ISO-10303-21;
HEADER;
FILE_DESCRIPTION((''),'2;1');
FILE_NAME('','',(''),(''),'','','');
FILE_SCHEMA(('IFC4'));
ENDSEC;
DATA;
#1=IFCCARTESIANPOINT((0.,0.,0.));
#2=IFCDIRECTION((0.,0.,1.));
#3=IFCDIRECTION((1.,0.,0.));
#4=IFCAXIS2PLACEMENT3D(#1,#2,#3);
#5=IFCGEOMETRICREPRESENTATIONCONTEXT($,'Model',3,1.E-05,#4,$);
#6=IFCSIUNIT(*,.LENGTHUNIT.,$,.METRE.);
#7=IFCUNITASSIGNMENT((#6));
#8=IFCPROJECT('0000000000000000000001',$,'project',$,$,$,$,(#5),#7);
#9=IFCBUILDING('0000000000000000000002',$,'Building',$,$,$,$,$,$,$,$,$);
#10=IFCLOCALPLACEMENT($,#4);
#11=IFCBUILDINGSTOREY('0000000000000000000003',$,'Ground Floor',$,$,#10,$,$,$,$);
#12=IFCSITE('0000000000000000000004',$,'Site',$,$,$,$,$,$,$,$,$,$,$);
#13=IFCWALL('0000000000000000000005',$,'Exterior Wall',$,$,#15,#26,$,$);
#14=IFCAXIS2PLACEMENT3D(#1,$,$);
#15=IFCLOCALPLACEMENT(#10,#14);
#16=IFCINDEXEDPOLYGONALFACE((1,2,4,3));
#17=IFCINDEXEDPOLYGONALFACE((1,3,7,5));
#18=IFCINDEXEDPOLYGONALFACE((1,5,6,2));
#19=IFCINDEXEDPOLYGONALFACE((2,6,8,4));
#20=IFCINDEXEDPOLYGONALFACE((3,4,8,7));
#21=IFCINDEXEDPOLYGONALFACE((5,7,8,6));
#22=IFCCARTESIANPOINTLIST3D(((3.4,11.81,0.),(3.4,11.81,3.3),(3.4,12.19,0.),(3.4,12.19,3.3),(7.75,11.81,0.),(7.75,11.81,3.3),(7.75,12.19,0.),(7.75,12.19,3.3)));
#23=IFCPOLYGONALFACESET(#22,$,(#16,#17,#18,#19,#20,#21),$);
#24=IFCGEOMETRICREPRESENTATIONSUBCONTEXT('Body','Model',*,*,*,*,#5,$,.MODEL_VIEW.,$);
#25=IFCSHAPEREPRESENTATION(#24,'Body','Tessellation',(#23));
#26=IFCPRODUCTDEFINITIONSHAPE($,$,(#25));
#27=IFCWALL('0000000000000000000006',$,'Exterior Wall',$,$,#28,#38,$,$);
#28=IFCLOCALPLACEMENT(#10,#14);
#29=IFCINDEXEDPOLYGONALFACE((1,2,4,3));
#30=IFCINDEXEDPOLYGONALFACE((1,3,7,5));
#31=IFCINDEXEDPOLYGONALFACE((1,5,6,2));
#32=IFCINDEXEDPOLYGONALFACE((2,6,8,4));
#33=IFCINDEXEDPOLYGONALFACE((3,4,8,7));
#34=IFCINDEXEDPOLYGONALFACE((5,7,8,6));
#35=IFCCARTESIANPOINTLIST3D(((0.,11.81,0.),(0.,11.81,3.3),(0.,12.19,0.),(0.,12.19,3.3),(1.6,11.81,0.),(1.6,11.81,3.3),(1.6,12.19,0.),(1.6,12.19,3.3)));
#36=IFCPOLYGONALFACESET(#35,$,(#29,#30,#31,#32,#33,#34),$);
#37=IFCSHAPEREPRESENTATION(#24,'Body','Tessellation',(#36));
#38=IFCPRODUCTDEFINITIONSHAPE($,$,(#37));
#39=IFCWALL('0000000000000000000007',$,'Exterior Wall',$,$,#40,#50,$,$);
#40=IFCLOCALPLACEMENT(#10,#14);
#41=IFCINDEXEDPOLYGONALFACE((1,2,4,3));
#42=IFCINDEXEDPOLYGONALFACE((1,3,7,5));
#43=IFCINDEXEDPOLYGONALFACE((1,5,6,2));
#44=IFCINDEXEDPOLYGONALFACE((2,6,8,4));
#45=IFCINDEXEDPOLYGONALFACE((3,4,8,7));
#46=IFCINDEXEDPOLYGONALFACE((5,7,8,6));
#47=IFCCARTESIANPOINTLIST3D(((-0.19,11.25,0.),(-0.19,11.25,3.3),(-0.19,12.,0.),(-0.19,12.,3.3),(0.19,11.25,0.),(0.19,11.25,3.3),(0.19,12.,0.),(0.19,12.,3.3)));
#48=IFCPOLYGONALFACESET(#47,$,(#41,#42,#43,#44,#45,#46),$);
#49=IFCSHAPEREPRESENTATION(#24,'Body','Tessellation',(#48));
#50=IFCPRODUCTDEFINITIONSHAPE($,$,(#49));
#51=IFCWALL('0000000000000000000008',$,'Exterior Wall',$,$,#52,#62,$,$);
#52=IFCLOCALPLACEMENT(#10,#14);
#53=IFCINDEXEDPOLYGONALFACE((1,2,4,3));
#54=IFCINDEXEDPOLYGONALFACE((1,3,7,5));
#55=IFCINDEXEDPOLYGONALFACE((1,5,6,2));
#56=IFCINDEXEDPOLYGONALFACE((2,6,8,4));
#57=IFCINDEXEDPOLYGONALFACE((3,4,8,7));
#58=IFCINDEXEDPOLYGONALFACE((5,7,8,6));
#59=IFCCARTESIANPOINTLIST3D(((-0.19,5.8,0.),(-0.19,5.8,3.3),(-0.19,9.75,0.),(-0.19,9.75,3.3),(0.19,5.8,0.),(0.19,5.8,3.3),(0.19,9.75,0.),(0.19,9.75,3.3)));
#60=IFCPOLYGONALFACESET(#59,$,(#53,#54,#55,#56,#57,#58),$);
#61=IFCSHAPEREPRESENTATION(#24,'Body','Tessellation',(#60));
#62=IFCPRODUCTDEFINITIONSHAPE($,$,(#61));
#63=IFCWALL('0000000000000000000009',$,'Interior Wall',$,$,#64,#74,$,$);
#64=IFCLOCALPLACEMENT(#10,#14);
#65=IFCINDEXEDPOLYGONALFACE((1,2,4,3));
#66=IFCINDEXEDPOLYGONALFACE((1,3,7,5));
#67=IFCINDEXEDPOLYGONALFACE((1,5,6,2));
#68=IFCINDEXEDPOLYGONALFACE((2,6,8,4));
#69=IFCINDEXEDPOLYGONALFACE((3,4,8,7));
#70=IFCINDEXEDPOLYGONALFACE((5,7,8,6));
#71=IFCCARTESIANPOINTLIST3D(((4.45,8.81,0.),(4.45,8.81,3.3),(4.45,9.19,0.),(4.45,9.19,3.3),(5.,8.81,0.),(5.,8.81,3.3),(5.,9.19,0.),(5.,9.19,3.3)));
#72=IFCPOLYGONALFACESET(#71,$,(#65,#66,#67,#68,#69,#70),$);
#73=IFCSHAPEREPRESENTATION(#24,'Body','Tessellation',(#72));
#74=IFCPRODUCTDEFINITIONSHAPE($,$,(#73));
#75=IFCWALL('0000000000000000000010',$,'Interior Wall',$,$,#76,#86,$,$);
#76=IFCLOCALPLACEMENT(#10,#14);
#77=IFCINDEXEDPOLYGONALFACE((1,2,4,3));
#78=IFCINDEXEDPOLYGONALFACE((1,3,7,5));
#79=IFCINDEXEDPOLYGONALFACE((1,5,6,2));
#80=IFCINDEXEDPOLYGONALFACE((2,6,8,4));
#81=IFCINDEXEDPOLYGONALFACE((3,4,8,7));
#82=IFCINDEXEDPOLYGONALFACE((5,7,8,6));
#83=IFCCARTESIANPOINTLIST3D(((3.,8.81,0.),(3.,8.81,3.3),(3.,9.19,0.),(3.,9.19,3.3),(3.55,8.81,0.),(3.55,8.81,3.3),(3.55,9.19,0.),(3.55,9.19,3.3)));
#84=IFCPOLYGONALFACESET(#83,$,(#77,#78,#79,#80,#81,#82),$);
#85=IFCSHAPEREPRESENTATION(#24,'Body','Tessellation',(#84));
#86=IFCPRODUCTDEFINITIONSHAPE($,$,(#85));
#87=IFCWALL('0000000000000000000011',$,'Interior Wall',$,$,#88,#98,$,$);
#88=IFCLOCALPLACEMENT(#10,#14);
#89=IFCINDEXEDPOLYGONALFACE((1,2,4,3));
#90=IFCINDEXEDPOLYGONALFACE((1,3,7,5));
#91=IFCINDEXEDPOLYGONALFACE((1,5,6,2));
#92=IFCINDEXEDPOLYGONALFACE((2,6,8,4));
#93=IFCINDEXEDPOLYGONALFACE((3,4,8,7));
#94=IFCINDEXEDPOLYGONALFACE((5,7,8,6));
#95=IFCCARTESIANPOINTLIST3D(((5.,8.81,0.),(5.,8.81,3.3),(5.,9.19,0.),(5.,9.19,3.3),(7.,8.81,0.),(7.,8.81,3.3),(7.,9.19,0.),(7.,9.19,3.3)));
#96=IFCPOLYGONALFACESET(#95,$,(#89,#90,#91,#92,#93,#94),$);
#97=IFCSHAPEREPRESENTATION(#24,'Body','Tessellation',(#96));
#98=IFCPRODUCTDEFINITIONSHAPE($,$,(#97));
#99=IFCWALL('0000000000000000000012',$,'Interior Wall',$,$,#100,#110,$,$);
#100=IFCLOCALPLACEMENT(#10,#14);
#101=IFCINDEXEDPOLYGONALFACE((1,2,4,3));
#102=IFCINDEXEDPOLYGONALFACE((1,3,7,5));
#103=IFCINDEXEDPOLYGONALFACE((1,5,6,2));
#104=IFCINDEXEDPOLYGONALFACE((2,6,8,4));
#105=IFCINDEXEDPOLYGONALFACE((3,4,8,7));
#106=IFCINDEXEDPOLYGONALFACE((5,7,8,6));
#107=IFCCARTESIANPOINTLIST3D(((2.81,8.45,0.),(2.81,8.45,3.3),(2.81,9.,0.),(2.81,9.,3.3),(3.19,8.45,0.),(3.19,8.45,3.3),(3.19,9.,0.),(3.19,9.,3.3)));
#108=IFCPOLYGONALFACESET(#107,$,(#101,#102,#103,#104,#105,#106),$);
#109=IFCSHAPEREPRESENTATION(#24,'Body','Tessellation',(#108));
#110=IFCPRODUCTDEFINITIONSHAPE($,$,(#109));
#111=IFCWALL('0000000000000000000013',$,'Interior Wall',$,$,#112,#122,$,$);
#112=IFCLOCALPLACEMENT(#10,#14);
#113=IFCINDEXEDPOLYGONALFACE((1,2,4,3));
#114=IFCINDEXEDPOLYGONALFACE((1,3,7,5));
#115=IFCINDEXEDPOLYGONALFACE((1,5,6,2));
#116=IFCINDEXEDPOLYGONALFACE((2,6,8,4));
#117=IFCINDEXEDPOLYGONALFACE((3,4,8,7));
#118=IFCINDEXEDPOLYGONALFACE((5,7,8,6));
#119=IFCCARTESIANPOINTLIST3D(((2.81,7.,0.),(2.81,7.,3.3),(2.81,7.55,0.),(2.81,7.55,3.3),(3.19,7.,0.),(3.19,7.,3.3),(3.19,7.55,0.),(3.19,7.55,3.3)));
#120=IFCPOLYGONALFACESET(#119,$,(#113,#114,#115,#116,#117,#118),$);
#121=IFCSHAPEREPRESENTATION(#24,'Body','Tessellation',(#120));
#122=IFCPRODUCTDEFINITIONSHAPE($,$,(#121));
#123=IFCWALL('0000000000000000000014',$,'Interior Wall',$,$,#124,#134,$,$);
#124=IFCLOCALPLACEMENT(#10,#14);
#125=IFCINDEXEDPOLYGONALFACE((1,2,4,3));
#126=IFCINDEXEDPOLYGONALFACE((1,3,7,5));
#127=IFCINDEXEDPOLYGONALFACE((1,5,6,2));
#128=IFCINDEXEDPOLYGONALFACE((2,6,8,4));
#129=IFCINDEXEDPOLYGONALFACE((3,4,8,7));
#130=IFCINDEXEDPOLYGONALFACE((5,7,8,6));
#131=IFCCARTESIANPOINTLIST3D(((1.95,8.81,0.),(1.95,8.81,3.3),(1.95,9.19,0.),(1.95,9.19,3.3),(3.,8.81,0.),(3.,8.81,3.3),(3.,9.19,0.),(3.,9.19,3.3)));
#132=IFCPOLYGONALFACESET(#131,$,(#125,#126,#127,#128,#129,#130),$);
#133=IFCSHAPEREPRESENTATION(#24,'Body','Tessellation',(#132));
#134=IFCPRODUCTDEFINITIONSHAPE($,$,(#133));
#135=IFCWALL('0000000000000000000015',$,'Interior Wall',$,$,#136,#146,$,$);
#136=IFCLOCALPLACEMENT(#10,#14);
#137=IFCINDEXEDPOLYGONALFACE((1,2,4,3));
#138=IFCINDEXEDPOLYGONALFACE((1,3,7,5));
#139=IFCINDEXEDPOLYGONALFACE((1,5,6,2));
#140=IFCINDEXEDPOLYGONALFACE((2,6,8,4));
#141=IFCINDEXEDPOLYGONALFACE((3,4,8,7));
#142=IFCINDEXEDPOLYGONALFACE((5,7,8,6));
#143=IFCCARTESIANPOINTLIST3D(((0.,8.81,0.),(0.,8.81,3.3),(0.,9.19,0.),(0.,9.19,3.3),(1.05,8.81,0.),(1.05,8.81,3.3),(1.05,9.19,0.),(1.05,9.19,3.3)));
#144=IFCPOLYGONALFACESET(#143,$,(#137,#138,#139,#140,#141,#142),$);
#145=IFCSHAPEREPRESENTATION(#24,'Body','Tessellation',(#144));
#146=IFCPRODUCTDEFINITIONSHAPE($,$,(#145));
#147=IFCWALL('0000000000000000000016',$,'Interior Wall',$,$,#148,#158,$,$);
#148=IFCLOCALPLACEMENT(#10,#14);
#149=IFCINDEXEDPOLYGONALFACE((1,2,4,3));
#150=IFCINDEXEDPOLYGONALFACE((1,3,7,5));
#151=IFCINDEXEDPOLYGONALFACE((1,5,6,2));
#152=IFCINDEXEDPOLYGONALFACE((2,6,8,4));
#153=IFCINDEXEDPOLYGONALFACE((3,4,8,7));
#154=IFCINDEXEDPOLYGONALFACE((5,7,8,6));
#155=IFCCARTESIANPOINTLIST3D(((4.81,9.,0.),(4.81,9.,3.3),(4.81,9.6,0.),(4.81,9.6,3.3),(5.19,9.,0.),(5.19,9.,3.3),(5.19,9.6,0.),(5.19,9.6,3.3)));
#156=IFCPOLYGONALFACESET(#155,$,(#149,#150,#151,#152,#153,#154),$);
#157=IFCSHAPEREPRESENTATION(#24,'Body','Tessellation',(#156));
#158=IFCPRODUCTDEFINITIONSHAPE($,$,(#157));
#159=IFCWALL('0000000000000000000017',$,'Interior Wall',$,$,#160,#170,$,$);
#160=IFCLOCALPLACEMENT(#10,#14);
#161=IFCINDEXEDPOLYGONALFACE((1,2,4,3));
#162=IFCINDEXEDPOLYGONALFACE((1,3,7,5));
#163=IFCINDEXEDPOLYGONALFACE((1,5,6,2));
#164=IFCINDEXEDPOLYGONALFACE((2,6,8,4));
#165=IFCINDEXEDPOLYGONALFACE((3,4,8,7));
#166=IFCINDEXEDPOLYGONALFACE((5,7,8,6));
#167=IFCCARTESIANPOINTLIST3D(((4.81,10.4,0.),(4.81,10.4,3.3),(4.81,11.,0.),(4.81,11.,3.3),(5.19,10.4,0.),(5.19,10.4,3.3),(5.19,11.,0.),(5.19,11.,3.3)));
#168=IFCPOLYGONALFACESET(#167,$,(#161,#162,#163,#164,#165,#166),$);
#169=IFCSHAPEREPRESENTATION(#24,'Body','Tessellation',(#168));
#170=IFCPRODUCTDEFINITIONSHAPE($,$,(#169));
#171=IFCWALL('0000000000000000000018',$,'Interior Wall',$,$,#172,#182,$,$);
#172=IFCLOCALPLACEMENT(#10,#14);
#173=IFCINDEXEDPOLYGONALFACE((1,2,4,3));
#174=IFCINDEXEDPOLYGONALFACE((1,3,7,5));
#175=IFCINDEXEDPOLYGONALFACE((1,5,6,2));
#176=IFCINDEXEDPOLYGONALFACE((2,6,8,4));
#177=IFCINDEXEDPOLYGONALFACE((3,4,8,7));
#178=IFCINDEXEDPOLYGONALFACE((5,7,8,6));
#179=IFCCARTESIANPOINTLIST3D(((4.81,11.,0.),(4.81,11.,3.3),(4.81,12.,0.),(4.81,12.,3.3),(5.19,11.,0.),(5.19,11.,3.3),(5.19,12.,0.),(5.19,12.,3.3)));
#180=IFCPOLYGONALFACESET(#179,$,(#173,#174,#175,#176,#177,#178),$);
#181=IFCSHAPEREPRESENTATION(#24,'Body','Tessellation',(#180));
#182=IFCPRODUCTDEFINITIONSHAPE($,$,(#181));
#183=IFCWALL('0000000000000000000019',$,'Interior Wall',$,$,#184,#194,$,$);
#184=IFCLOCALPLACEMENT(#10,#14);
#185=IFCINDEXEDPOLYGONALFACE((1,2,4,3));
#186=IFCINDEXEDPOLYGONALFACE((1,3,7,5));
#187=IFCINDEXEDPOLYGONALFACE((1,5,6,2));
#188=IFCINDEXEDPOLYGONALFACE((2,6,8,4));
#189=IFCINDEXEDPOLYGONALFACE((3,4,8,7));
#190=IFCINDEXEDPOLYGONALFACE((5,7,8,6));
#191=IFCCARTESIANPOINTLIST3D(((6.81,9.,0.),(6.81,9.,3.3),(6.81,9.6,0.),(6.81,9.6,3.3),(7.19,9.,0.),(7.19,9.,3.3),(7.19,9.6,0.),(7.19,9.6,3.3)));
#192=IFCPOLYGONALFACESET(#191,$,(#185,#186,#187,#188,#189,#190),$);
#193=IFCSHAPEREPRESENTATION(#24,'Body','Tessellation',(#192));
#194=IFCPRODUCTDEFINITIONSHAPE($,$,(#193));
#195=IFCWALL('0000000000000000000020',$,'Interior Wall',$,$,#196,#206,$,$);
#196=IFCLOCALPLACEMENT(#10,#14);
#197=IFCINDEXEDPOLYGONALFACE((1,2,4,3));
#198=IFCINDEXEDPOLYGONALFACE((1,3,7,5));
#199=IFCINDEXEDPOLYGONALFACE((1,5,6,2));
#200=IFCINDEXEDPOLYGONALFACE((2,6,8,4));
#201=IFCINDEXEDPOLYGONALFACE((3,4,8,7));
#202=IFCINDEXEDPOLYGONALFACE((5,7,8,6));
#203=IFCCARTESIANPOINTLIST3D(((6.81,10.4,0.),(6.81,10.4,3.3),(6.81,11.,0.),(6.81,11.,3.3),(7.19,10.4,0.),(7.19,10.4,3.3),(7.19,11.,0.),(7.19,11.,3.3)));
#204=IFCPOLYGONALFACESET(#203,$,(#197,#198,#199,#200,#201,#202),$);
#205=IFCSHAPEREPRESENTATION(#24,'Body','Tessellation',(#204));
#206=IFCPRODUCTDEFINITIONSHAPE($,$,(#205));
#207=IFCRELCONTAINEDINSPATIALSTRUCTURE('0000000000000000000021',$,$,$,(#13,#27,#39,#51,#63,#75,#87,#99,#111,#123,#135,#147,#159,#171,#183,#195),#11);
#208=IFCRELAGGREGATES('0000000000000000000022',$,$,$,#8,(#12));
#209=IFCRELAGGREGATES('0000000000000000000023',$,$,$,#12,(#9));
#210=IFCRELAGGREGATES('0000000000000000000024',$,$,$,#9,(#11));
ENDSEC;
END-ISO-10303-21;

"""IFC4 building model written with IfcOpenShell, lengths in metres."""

from ifc_helpers import new_model, si_unit, frame, origin_with_axes, place, context, subcontext, project, spatial, indexed_curve, outline, extrude, element, save


model = new_model("IFC4")

# Units and contexts
model_context = context("Model", 3, precision=1e-05, world=origin_with_axes())
body_context = subcontext(model_context, "Body", "Model", "MODEL_VIEW")
ifc_project = project(units=[si_unit("LENGTHUNIT", "METRE")], contexts=[model_context])

# Site, building, storey
site = spatial("IfcSite", under=ifc_project, Name="Site")
building = spatial("IfcBuilding", under=site, Name="Building")
storey_placement = place(None, origin_with_axes())
storey = spatial("IfcBuildingStorey", under=building, at=storey_placement, Name="Ground Floor")

# Walls
wall_1_placement = place(storey_placement, frame((7.75, 12.0, 0.0), z_axis=(0.0, 0.0, 1.0), x_axis=(-1.0, 0.0, 0.0)))
element("IfcWall", 1, at=wall_1_placement, inside=storey, Name="Exterior Wall", context=body_context, shape_type="SweptSolid", body=[
    extrude(outline(indexed_curve([(0.0, 0.0), (0.0, 0.38), (4.35, 0.38), (4.35, 0.0), (0.0, 0.0)], self_intersect=False)), frame((0.0, -0.19, 0.0), z_axis=(0.0, 0.0, 1.0), x_axis=(1.0, 0.0, 0.0)), (0.0, 0.0, 1.0), 3.3),
])
wall_2_placement = place(storey_placement, frame((1.6, 12.0, 0.0), z_axis=(0.0, 0.0, 1.0), x_axis=(-1.0, 0.0, 0.0)))
element("IfcWall", 2, at=wall_2_placement, inside=storey, Name="Exterior Wall", context=body_context, shape_type="SweptSolid", body=[
    extrude(outline(indexed_curve([(0.0, 0.0), (0.0, 0.38), (1.6, 0.38), (1.6, 0.0), (0.0, 0.0)], self_intersect=False)), frame((0.0, -0.19, 0.0), z_axis=(0.0, 0.0, 1.0), x_axis=(1.0, 0.0, 0.0)), (0.0, 0.0, 1.0), 3.3),
])
wall_3_placement = place(storey_placement, frame((0.0, 12.0, 0.0), z_axis=(0.0, 0.0, 1.0), x_axis=(0.0, -1.0, 0.0)))
element("IfcWall", 3, at=wall_3_placement, inside=storey, Name="Exterior Wall", context=body_context, shape_type="SweptSolid", body=[
    extrude(outline(indexed_curve([(0.0, 0.0), (0.0, 0.38), (0.75, 0.38), (0.75, 0.0), (0.0, 0.0)], self_intersect=False)), frame((0.0, -0.19, 0.0), z_axis=(0.0, 0.0, 1.0), x_axis=(1.0, 0.0, 0.0)), (0.0, 0.0, 1.0), 3.3),
])
wall_4_placement = place(storey_placement, frame((0.0, 9.75, 0.0), z_axis=(0.0, 0.0, 1.0), x_axis=(0.0, -1.0, 0.0)))
element("IfcWall", 4, at=wall_4_placement, inside=storey, Name="Exterior Wall", context=body_context, shape_type="SweptSolid", body=[
    extrude(outline(indexed_curve([(0.0, 0.0), (0.0, 0.38), (3.95, 0.38), (3.95, 0.0), (0.0, 0.0)], self_intersect=False)), frame((0.0, -0.19, 0.0), z_axis=(0.0, 0.0, 1.0), x_axis=(1.0, 0.0, 0.0)), (0.0, 0.0, 1.0), 3.3),
])
for number, where, z_axis, x_axis, name in (
    (5, (5.0, 9.0, 0.0), (0.0, 0.0, 1.0), (-1.0, 0.0, 0.0), "Interior Wall"),
    (6, (3.55, 9.0, 0.0), (0.0, 0.0, 1.0), (-1.0, 0.0, 0.0), "Interior Wall"),
):
    element("IfcWall", number, at=place(storey_placement, frame(where, z_axis=z_axis, x_axis=x_axis)), inside=storey, Name=name, context=body_context, shape_type="SweptSolid", body=[
        extrude(outline(indexed_curve([(0.0, 0.0), (0.0, 0.38), (0.55, 0.38), (0.55, 0.0), (0.0, 0.0)], self_intersect=False)), frame((0.0, -0.19, 0.0), z_axis=(0.0, 0.0, 1.0), x_axis=(1.0, 0.0, 0.0)), (0.0, 0.0, 1.0), 3.3),
    ])
wall_5_placement = place(storey_placement, frame((7.0, 9.0, 0.0), z_axis=(0.0, 0.0, 1.0), x_axis=(-1.0, 0.0, 0.0)))
element("IfcWall", 7, at=wall_5_placement, inside=storey, Name="Interior Wall", context=body_context, shape_type="SweptSolid", body=[
    extrude(outline(indexed_curve([(0.0, 0.0), (0.0, 0.38), (2.0, 0.38), (2.0, 0.0), (0.0, 0.0)], self_intersect=False)), frame((0.0, -0.19, 0.0), z_axis=(0.0, 0.0, 1.0), x_axis=(1.0, 0.0, 0.0)), (0.0, 0.0, 1.0), 3.3),
])
wall_6_placement = place(storey_placement, frame((3.0, 9.0, 0.0), z_axis=(0.0, 0.0, 1.0), x_axis=(0.0, -1.0, 0.0)))
element("IfcWall", 8, at=wall_6_placement, inside=storey, Name="Interior Wall", context=body_context, shape_type="SweptSolid", body=[
    extrude(outline(indexed_curve([(0.0, 0.0), (0.0, 0.38), (0.55, 0.38), (0.55, 0.0), (0.0, 0.0)], self_intersect=False)), frame((0.0, -0.19, 0.0), z_axis=(0.0, 0.0, 1.0), x_axis=(1.0, 0.0, 0.0)), (0.0, 0.0, 1.0), 3.3),
])
wall_7_placement = place(storey_placement, frame((3.0, 7.55, 0.0), z_axis=(0.0, 0.0, 1.0), x_axis=(0.0, -1.0, 0.0)))
element("IfcWall", 9, at=wall_7_placement, inside=storey, Name="Interior Wall", context=body_context, shape_type="SweptSolid", body=[
    extrude(outline(indexed_curve([(0.0, 0.0), (0.0, 0.38), (0.55, 0.38), (0.55, 0.0), (0.0, 0.0)], self_intersect=False)), frame((0.0, -0.19, 0.0), z_axis=(0.0, 0.0, 1.0), x_axis=(1.0, 0.0, 0.0)), (0.0, 0.0, 1.0), 3.3),
])
for number, where, z_axis, x_axis, name in (
    (10, (3.0, 9.0, 0.0), (0.0, 0.0, 1.0), (-1.0, 0.0, 0.0), "Interior Wall"),
    (11, (1.05, 9.0, 0.0), (0.0, 0.0, 1.0), (-1.0, 0.0, 0.0), "Interior Wall"),
):
    element("IfcWall", number, at=place(storey_placement, frame(where, z_axis=z_axis, x_axis=x_axis)), inside=storey, Name=name, context=body_context, shape_type="SweptSolid", body=[
        extrude(outline(indexed_curve([(0.0, 0.0), (0.0, 0.38), (1.05, 0.38), (1.05, 0.0), (0.0, 0.0)], self_intersect=False)), frame((0.0, -0.19, 0.0), z_axis=(0.0, 0.0, 1.0), x_axis=(1.0, 0.0, 0.0)), (0.0, 0.0, 1.0), 3.3),
    ])
for number, where, z_axis, x_axis, name in (
    (12, (5.0, 9.0, 0.0), (0.0, 0.0, 1.0), (0.0, 1.0, 0.0), "Interior Wall"),
    (13, (5.0, 10.4, 0.0), (0.0, 0.0, 1.0), (0.0, 1.0, 0.0), "Interior Wall"),
):
    element("IfcWall", number, at=place(storey_placement, frame(where, z_axis=z_axis, x_axis=x_axis)), inside=storey, Name=name, context=body_context, shape_type="SweptSolid", body=[
        extrude(outline(indexed_curve([(0.0, 0.0), (0.0, 0.38), (0.6, 0.38), (0.6, 0.0), (0.0, 0.0)], self_intersect=False)), frame((0.0, -0.19, 0.0), z_axis=(0.0, 0.0, 1.0), x_axis=(1.0, 0.0, 0.0)), (0.0, 0.0, 1.0), 3.3),
    ])
wall_8_placement = place(storey_placement, frame((5.0, 11.0, 0.0), z_axis=(0.0, 0.0, 1.0), x_axis=(0.0, 1.0, 0.0)))
element("IfcWall", 14, at=wall_8_placement, inside=storey, Name="Interior Wall", context=body_context, shape_type="SweptSolid", body=[
    extrude(outline(indexed_curve([(0.0, 0.0), (0.0, 0.38), (1.0, 0.38), (1.0, 0.0), (0.0, 0.0)], self_intersect=False)), frame((0.0, -0.19, 0.0), z_axis=(0.0, 0.0, 1.0), x_axis=(1.0, 0.0, 0.0)), (0.0, 0.0, 1.0), 3.3),
])
for number, where, z_axis, x_axis, name in (
    (15, (7.0, 9.0, 0.0), (0.0, 0.0, 1.0), (0.0, 1.0, 0.0), "Interior Wall"),
    (16, (7.0, 10.4, 0.0), (0.0, 0.0, 1.0), (0.0, 1.0, 0.0), "Interior Wall"),
):
    element("IfcWall", number, at=place(storey_placement, frame(where, z_axis=z_axis, x_axis=x_axis)), inside=storey, Name=name, context=body_context, shape_type="SweptSolid", body=[
        extrude(outline(indexed_curve([(0.0, 0.0), (0.0, 0.38), (0.6, 0.38), (0.6, 0.0), (0.0, 0.0)], self_intersect=False)), frame((0.0, -0.19, 0.0), z_axis=(0.0, 0.0, 1.0), x_axis=(1.0, 0.0, 0.0)), (0.0, 0.0, 1.0), 3.3),
    ])

save(model, "model.ifc")
